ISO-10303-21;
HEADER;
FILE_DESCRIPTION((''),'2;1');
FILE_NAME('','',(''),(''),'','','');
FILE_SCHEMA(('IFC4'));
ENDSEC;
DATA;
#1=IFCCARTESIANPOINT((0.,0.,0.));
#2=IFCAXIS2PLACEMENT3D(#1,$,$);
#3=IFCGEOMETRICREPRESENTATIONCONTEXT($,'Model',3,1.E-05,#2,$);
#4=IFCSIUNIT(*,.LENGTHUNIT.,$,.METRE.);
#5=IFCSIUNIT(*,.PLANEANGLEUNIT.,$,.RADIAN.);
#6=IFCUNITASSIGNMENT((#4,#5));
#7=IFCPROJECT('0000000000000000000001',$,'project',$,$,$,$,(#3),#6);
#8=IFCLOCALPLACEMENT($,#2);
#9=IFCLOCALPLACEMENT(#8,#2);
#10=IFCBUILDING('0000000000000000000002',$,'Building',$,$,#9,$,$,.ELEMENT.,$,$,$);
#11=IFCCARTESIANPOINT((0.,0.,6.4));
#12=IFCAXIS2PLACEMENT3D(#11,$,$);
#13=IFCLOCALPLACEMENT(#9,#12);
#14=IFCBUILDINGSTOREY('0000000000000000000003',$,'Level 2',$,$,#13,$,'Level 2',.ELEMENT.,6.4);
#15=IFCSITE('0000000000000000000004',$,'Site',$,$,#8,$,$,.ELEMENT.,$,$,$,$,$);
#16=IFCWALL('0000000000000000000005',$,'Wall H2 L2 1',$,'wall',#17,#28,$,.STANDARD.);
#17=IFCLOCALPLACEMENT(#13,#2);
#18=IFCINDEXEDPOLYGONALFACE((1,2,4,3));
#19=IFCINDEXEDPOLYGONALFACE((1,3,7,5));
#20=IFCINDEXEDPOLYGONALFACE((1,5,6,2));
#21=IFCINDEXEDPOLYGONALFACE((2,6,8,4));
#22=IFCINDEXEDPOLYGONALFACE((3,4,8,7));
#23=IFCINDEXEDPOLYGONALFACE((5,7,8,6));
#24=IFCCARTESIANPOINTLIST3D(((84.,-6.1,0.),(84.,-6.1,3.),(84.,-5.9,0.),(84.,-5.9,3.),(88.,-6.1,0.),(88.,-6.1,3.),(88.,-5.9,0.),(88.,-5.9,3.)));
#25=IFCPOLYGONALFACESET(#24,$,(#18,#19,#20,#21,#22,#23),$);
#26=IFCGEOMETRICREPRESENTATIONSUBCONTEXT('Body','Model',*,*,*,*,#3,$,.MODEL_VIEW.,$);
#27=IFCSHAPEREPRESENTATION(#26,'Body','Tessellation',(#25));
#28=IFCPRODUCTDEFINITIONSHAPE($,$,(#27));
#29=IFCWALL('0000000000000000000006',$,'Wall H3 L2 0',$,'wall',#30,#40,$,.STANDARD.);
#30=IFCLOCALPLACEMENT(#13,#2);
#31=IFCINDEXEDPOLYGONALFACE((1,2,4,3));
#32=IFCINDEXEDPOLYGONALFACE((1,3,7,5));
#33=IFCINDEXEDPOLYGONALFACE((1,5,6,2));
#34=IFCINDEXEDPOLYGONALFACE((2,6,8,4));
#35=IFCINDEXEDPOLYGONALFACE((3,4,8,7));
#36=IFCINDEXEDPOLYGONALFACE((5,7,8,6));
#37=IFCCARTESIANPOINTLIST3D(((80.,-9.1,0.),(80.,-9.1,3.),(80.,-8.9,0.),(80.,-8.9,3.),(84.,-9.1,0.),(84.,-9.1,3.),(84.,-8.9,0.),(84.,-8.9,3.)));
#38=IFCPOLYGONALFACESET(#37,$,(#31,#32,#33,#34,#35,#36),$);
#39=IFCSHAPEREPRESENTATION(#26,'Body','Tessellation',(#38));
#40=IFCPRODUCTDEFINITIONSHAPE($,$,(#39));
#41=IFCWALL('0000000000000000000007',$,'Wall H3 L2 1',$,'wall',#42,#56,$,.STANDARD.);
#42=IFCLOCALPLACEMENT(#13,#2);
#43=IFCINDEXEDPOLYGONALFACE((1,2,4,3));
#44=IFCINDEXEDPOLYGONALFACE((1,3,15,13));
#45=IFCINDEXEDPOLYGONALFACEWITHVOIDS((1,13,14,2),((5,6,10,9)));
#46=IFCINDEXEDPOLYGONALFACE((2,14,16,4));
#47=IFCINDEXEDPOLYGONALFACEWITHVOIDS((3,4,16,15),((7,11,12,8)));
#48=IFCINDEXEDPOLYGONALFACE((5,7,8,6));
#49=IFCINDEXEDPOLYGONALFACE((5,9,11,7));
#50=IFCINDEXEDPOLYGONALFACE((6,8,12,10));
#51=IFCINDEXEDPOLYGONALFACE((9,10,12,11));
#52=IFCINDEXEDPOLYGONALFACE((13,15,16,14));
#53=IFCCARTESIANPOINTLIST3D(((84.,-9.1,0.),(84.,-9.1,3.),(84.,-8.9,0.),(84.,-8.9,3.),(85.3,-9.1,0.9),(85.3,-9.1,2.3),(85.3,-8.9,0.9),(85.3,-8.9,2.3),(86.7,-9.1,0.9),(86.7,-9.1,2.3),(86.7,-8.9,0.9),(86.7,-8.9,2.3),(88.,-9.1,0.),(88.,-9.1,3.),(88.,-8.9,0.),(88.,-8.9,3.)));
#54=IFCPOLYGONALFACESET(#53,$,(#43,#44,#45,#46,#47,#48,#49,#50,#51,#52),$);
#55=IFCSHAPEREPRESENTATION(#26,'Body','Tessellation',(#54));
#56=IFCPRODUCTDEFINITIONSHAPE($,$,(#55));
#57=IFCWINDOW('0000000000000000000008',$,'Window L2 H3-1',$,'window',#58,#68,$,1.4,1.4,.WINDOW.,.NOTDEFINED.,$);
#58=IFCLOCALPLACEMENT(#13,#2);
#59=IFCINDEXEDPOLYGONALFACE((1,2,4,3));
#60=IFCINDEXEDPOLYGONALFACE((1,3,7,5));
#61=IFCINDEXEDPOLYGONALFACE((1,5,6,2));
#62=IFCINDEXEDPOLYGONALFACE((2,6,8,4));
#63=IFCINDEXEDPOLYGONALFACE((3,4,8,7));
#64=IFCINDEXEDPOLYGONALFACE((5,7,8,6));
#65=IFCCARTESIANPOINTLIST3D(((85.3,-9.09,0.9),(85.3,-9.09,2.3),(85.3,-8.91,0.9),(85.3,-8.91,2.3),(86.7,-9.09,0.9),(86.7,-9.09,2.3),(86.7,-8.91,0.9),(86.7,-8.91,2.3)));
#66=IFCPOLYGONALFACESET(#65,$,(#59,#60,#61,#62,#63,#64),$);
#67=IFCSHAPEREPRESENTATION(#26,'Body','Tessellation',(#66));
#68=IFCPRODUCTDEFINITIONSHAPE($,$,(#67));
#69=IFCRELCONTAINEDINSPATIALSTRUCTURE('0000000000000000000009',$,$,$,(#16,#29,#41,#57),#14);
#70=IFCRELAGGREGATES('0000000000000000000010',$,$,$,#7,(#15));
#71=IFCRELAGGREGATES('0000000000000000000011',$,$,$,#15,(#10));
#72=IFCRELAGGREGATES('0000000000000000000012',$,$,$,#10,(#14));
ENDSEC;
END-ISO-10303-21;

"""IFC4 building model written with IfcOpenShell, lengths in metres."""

from ifc_helpers import new_model, si_unit, frame, frame_2d, origin, origin_2d, place, context, subcontext, project, spatial, rectangle, extrude, element, fill, save


model = new_model("IFC4")

# Units and contexts
model_context = context("Model", 3, precision=1e-05, world=origin())
body_context = subcontext(model_context, "Body", "Model", "MODEL_VIEW")
ifc_project = project(units=[si_unit("LENGTHUNIT", "METRE"), si_unit("PLANEANGLEUNIT", "RADIAN")], contexts=[model_context])

# Site, building, storey
site_placement = place(None, origin())
site = spatial("IfcSite", under=ifc_project, at=site_placement, Name="Site", CompositionType="ELEMENT")
building_placement = place(site_placement, origin())
building = spatial("IfcBuilding", under=site, at=building_placement, Name="Building", CompositionType="ELEMENT")
storey_placement = place(building_placement, frame((0.0, 0.0, 6.4)))
storey = spatial("IfcBuildingStorey", under=building, at=storey_placement, Name="Level 2", LongName="Level 2", CompositionType="ELEMENT", Elevation=6.4)

# Walls
for number, where, z_axis, x_axis, name in (
    (1, (84.0, -6.0, 0.0), (0.0, 0.0, 1.0), (1.0, 0.0, 0.0), "Wall H2 L2 1"),
    (2, (80.0, -9.0, 0.0), (0.0, 0.0, 1.0), (1.0, 0.0, 0.0), "Wall H3 L2 0"),
):
    element("IfcWall", number, at=place(storey_placement, frame(where, z_axis=z_axis, x_axis=x_axis)), inside=storey, Name=name, ObjectType="wall", PredefinedType="STANDARD", context=body_context, shape_type="SweptSolid", body=[
        extrude(rectangle(XDim=4.0, YDim=0.2, at=frame_2d((2.0, 0.0))), origin(), (0.0, 0.0, 1.0), 3.0),
    ])

# Wall, opening, window
wall_1_placement = place(storey_placement, frame((84.0, -9.0, 0.0), z_axis=(0.0, 0.0, 1.0), x_axis=(1.0, 0.0, 0.0)))
wall_1 = element("IfcWall", 3, at=wall_1_placement, inside=storey, Name="Wall H3 L2 1", ObjectType="wall", PredefinedType="STANDARD", context=body_context, shape_type="SweptSolid", body=[
    extrude(rectangle(XDim=4.0, YDim=0.2, at=frame_2d((2.0, 0.0))), origin(), (0.0, 0.0, 1.0), 3.0),
])
opening_1_placement = place(storey_placement, frame((86.0, -9.0, 0.9), z_axis=(0.0, 0.0, 1.0), x_axis=(1.0, 0.0, 0.0)))
opening_1 = element("IfcOpeningElement", 4, at=opening_1_placement, cuts=wall_1, ObjectType="Opening", PredefinedType="OPENING", context=body_context, shape_type="SweptSolid", body=[
    extrude(rectangle(XDim=1.4, YDim=0.22, at=origin_2d()), origin(), (0.0, 0.0, 1.0), 1.4),
])
window_1_placement = place(storey_placement, frame((86.0, -9.0, 0.9), z_axis=(0.0, 0.0, 1.0), x_axis=(1.0, 0.0, 0.0)))
window_1 = element("IfcWindow", 5, at=window_1_placement, inside=storey, Name="Window L2 H3-1", ObjectType="window", OverallHeight=1.4, OverallWidth=1.4, PartitioningType="NOTDEFINED", PredefinedType="WINDOW", context=body_context, shape_type="SweptSolid", body=[
    extrude(rectangle(XDim=1.4, YDim=0.18, at=origin_2d()), origin(), (0.0, 0.0, 1.0), 1.4),
])
fill(opening_1, window_1)

save(model, "model.ifc")
